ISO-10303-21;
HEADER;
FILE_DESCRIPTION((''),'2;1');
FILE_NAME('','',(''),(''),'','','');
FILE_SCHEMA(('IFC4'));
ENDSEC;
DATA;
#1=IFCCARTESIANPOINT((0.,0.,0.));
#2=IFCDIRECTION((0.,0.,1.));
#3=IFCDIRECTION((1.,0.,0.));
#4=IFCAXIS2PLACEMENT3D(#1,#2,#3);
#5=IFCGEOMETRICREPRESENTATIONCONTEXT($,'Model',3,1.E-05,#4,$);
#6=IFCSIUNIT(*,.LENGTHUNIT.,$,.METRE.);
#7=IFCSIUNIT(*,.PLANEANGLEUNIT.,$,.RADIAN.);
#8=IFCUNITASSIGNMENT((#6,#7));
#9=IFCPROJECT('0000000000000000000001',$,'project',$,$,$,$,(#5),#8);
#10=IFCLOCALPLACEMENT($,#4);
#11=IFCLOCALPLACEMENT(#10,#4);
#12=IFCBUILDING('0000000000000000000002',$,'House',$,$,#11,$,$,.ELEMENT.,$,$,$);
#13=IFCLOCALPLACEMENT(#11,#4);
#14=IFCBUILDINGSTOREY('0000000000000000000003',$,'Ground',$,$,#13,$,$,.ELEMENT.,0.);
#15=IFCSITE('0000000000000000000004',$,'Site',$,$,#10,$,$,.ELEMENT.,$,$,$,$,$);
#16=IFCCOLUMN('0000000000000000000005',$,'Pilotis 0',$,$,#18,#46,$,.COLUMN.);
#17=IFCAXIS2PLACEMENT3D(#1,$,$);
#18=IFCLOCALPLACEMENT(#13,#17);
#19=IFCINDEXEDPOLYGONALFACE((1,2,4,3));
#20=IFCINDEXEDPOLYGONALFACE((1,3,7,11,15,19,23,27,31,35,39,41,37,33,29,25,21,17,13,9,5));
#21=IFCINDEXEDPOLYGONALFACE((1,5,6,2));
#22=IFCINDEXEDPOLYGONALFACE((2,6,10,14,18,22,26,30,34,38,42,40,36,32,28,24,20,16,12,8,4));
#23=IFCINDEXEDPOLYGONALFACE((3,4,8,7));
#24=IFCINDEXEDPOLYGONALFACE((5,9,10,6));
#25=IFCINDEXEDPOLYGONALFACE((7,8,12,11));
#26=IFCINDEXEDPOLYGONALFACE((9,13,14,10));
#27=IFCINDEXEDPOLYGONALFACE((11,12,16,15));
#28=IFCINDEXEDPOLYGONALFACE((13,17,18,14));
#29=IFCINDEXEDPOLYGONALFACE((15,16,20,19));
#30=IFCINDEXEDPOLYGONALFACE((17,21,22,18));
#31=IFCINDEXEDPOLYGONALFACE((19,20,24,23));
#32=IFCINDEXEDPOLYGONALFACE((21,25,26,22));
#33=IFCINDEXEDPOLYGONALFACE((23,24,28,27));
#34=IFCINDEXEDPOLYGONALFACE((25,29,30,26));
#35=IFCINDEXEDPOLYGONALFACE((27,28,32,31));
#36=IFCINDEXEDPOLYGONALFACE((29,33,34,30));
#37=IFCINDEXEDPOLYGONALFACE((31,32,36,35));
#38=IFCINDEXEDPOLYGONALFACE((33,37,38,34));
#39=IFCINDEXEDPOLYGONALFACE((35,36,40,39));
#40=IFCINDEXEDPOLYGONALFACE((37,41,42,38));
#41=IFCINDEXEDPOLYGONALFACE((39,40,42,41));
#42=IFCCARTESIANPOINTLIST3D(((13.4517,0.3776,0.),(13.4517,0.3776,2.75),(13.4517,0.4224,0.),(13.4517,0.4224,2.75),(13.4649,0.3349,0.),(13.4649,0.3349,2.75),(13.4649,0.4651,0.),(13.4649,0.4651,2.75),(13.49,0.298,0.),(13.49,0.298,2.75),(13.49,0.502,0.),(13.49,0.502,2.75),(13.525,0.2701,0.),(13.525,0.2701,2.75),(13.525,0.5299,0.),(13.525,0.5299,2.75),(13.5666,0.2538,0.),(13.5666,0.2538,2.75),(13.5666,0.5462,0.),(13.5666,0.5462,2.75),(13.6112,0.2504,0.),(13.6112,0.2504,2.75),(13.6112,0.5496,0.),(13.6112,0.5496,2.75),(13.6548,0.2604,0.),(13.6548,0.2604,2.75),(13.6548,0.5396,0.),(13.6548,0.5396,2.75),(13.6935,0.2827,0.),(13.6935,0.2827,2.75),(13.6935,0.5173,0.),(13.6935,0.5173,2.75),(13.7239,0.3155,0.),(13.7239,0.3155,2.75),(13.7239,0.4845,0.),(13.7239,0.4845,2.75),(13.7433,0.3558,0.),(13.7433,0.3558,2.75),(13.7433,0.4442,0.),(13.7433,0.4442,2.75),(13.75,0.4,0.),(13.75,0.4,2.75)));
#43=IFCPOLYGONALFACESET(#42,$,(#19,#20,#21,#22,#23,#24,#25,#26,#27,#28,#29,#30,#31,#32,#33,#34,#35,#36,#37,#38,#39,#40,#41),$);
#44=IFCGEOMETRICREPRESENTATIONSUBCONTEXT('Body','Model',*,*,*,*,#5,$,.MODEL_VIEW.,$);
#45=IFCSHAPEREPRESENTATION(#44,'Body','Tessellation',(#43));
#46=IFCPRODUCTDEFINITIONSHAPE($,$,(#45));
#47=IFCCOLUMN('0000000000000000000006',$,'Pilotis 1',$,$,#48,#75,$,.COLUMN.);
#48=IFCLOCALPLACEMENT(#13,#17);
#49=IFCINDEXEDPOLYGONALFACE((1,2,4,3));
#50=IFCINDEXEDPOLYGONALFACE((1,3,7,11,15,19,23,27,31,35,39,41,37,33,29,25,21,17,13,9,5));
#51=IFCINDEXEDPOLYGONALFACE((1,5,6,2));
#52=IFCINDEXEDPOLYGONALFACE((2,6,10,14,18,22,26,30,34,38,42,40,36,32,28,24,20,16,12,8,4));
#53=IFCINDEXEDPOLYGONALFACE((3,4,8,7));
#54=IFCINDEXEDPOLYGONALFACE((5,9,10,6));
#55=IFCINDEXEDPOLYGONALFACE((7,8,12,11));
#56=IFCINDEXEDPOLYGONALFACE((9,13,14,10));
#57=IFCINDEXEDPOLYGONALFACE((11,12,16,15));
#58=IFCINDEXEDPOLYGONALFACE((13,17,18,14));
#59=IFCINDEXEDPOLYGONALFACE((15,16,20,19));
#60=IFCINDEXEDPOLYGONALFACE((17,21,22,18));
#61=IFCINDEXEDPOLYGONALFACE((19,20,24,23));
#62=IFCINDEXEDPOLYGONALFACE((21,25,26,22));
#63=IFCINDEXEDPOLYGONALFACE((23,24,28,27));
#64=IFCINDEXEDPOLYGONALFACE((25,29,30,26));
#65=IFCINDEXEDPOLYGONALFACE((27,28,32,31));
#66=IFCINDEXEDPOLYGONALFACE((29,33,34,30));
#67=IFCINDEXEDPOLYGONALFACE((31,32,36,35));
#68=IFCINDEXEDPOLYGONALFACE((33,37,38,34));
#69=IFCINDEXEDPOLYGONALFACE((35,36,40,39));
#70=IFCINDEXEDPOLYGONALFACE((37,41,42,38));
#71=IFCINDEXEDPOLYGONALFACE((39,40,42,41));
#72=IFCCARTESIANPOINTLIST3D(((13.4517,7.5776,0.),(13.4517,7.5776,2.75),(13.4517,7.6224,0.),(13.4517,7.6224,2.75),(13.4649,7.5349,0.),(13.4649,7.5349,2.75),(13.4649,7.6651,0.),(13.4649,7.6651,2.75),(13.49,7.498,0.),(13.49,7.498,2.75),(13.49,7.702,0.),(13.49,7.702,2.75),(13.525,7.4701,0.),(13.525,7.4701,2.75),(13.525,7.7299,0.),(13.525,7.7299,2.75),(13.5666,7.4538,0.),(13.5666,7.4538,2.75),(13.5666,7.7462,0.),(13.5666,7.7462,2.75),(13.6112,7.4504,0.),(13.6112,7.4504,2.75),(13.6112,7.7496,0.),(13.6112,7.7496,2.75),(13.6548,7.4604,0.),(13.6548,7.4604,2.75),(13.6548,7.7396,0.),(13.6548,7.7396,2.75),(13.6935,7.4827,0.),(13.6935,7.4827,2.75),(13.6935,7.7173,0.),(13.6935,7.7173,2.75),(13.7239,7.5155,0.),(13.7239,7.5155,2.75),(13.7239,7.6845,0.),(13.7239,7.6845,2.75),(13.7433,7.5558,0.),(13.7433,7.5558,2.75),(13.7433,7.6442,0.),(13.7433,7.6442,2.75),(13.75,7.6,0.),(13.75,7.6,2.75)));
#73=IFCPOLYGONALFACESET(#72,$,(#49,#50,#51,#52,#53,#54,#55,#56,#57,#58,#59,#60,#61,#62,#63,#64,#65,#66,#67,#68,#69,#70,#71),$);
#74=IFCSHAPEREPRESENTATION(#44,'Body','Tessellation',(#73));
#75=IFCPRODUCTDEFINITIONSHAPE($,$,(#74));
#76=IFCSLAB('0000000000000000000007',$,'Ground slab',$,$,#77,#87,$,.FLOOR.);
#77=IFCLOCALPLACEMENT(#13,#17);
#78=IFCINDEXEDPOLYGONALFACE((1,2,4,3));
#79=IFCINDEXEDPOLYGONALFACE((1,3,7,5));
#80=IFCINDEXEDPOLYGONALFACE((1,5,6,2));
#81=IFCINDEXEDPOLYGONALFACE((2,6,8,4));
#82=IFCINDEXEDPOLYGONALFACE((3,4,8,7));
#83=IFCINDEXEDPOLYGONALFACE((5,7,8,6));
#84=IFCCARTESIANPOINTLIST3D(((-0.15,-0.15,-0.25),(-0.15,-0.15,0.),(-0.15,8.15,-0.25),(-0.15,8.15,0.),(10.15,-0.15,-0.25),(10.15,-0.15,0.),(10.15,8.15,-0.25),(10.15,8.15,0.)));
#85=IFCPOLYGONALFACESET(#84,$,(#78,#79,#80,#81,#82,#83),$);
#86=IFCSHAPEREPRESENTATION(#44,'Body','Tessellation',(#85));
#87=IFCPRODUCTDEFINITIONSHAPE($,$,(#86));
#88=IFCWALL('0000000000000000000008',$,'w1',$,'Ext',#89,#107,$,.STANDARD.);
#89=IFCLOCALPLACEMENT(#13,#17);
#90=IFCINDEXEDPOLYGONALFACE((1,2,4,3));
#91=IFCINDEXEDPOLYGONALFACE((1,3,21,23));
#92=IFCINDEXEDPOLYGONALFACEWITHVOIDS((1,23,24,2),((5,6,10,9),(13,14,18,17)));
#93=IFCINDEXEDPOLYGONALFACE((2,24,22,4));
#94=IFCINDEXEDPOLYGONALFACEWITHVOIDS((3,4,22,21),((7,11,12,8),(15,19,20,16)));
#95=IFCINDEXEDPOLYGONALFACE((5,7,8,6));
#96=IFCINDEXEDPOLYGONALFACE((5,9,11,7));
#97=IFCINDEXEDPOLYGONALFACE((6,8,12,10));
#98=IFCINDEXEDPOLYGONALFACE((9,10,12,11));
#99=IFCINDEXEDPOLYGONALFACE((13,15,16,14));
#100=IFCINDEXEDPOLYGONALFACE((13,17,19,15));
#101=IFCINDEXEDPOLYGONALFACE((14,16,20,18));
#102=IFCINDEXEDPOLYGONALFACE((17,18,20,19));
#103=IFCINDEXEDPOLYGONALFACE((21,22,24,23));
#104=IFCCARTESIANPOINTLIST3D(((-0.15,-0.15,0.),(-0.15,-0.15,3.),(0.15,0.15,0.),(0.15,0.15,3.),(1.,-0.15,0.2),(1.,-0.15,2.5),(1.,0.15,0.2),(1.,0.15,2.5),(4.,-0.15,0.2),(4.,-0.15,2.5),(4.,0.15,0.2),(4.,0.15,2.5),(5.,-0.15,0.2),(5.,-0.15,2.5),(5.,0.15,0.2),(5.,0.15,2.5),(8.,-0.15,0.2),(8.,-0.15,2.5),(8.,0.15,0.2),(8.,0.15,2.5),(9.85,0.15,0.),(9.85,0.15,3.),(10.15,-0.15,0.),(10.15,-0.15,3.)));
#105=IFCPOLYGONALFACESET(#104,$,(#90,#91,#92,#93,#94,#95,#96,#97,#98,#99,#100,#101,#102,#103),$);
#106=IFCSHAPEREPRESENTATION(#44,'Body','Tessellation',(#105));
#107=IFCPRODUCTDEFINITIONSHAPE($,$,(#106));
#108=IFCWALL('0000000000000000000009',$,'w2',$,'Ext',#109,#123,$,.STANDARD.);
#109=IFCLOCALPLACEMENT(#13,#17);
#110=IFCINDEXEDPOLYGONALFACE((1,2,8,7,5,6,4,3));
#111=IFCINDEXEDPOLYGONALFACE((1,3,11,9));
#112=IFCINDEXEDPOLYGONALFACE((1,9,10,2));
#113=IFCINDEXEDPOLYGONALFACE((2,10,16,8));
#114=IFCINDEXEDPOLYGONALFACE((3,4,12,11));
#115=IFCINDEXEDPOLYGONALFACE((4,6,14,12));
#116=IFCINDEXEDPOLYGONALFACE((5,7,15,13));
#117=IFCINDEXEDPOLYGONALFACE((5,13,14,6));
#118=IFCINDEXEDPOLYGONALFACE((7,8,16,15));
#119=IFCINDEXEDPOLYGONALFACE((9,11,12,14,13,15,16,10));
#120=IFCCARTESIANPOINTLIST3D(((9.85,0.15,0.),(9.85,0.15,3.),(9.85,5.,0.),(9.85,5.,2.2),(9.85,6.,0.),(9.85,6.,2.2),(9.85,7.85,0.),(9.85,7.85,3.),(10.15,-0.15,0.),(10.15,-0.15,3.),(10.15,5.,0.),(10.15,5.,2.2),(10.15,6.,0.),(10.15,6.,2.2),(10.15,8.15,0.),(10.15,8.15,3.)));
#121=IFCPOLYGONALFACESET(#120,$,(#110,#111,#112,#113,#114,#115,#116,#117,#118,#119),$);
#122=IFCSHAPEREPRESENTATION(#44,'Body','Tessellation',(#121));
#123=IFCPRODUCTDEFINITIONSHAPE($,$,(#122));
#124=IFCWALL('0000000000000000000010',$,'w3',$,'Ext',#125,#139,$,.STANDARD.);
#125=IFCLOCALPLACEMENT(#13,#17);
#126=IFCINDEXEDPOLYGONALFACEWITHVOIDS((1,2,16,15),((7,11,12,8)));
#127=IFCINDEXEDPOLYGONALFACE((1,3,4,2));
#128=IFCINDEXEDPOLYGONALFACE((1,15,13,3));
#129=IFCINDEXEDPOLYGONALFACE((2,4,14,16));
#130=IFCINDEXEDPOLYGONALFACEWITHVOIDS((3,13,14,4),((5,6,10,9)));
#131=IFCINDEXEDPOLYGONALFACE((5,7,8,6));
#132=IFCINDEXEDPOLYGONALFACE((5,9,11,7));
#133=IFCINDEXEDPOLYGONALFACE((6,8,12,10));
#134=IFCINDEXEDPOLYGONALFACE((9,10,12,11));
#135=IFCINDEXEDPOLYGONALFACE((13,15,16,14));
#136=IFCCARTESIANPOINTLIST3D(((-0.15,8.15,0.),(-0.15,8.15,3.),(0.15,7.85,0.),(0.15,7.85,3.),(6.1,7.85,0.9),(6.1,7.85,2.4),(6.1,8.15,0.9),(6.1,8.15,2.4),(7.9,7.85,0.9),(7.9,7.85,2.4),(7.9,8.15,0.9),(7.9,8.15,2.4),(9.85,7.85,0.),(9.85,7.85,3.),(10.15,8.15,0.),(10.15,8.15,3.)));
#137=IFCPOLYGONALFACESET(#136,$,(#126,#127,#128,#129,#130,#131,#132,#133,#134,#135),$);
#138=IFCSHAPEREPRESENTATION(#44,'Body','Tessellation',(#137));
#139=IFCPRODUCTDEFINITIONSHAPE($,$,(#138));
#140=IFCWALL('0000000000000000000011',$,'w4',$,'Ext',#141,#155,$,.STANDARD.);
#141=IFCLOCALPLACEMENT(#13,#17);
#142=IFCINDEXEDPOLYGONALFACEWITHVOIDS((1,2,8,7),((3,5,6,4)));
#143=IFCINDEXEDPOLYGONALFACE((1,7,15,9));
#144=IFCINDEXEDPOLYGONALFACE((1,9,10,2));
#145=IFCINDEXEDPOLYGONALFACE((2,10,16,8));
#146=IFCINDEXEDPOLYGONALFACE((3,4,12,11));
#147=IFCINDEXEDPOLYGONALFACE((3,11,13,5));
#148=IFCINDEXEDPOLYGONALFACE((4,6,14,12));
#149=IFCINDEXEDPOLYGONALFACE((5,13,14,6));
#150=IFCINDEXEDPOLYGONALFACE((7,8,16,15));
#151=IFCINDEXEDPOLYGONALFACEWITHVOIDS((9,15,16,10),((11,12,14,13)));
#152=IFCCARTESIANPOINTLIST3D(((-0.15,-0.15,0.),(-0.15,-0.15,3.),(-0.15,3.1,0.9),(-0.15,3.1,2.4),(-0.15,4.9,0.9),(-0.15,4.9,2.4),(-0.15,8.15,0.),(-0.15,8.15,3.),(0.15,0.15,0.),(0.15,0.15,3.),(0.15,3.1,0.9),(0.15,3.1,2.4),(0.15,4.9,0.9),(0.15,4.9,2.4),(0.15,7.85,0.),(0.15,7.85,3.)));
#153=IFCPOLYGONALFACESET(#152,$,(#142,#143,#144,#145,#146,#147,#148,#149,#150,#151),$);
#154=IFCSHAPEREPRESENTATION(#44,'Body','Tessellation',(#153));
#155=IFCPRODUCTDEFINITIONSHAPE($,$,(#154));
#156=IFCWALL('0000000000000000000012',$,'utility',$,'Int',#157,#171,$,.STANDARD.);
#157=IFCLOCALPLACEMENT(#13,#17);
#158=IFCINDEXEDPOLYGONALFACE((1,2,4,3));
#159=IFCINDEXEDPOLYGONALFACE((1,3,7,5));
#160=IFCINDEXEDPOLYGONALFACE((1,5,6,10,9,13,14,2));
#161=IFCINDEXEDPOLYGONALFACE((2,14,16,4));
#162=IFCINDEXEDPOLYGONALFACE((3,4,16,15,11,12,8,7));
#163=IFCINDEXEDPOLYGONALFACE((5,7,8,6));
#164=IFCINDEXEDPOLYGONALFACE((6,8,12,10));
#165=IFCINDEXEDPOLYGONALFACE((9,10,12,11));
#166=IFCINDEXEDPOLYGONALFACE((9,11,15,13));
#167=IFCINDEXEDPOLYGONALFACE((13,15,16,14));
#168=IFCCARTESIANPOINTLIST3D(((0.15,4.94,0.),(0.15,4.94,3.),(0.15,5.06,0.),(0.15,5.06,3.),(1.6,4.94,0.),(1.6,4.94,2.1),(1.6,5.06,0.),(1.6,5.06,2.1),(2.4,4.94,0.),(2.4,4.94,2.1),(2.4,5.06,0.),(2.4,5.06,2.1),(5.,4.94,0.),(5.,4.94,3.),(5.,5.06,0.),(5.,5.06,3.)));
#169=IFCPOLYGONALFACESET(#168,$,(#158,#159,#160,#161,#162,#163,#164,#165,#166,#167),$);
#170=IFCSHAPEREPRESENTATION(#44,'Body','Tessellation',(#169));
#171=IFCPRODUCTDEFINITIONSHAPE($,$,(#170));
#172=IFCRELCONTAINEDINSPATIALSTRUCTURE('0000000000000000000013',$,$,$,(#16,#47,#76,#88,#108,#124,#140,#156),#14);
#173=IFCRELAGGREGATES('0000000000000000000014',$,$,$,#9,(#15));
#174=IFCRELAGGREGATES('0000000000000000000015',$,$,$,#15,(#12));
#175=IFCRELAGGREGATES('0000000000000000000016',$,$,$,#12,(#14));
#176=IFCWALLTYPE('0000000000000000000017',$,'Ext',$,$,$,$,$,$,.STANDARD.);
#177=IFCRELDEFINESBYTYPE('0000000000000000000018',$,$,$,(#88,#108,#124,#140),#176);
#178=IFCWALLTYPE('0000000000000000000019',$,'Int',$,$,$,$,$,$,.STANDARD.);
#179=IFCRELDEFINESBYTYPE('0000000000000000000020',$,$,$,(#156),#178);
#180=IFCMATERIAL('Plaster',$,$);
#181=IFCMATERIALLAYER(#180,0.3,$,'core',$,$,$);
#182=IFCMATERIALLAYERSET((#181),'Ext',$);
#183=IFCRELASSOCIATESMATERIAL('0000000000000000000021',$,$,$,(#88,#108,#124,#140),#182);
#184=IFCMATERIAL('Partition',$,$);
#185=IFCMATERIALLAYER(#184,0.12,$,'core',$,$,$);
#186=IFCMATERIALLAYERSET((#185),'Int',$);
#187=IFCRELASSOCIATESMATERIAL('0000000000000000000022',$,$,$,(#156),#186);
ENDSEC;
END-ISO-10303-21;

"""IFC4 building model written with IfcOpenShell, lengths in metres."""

from ifc_helpers import new_model, si_unit, frame, origin_with_axes, origin_2d_with_axis, place, context, subcontext, project, spatial, polyline, rectangle, circle, outline, extrude, material, layer, layer_set, layer_usage, type_object, element, save


model = new_model("IFC4")

# Units and contexts
model_context = context("Model", 3, precision=1e-05, world=origin_with_axes())
body_context = subcontext(model_context, "Body", "Model", "MODEL_VIEW")
ifc_project = project(units=[si_unit("LENGTHUNIT", "METRE"), si_unit("PLANEANGLEUNIT", "RADIAN")], contexts=[model_context])

# Site, building, storey
site_placement = place(None, origin_with_axes())
site = spatial("IfcSite", under=ifc_project, at=site_placement, Name="Site", CompositionType="ELEMENT")
building_placement = place(site_placement, origin_with_axes())
building = spatial("IfcBuilding", under=site, at=building_placement, Name="House", CompositionType="ELEMENT")
storey_placement = place(building_placement, origin_with_axes())
storey = spatial("IfcBuildingStorey", under=building, at=storey_placement, Name="Ground", CompositionType="ELEMENT", Elevation=0.0)

# Columns
for number, where, z_axis, x_axis, name in (
    (1, (13.6, 0.4, 0.0), (0.0, 0.0, 1.0), (1.0, 0.0, 0.0), "Pilotis 0"),
    (2, (13.6, 7.6, 0.0), (0.0, 0.0, 1.0), (1.0, 0.0, 0.0), "Pilotis 1"),
):
    element("IfcColumn", number, at=place(storey_placement, frame(where, z_axis=z_axis, x_axis=x_axis)), inside=storey, Name=name, PredefinedType="COLUMN", context=body_context, shape_type="SweptSolid", body=[
        extrude(circle(Radius=0.15, at=origin_2d_with_axis()), origin_with_axes(), (0.0, 0.0, 1.0), 2.75),
    ])

# Slab
slab_placement = place(storey_placement, frame((0.0, 0.0, -0.25), z_axis=(0.0, 0.0, 1.0), x_axis=(1.0, 0.0, 0.0)))
element("IfcSlab", 3, at=slab_placement, inside=storey, Name="Ground slab", PredefinedType="FLOOR", context=body_context, shape_type="SweptSolid", body=[
    extrude(outline(polyline([(10.15, -0.15), (10.15, 8.15), (-0.15, 8.15), (-0.15, -0.15), (10.15, -0.15)])), origin_with_axes(), (0.0, 0.0, 1.0), 0.25),
])

# Wall, openings
ifc_material_1 = material(Name="Plaster")
ifc_layer_1 = layer(ifc_material_1, 0.3, Name="core")
ifc_layer_set_1 = layer_set([ifc_layer_1], Name="Ext")
ifc_layer_usage_1 = layer_usage(ifc_layer_set_1, "AXIS2", "POSITIVE", -0.15)
wall_type_1 = type_object("IfcWallType", Name="Ext", PredefinedType="STANDARD")
wall_1_placement = place(storey_placement, origin_with_axes())
wall_1 = element("IfcWall", 4, at=wall_1_placement, inside=storey, type_object=wall_type_1, material=ifc_layer_usage_1, Name="w1", ObjectType="Ext", PredefinedType="STANDARD", context=body_context, shape_type="SweptSolid", body=[
    extrude(outline(polyline([(-0.15, -0.15), (10.15, -0.15), (10.0, 0.0), (9.85, 0.15), (0.15, 0.15), (0.0, 0.0), (-0.15, -0.15)])), origin_with_axes(), (0.0, 0.0, 1.0), 3.0),
])
opening_1_placement = place(wall_1_placement, frame((2.5, -0.16, 1.35), z_axis=(0.0, 1.0, 0.0), x_axis=(1.0, 0.0, 0.0)))
element("IfcOpeningElement", 5, at=opening_1_placement, cuts=wall_1, PredefinedType="OPENING", context=body_context, shape_type="SweptSolid", body=[
    extrude(rectangle(XDim=3.0, YDim=2.3, at=origin_2d_with_axis()), origin_with_axes(), (0.0, 0.0, 1.0), 0.32),
])
opening_2_placement = place(wall_1_placement, frame((6.5, -0.16, 1.35), z_axis=(0.0, 1.0, 0.0), x_axis=(1.0, 0.0, 0.0)))
element("IfcOpeningElement", 6, at=opening_2_placement, cuts=wall_1, PredefinedType="OPENING", context=body_context, shape_type="SweptSolid", body=[
    extrude(rectangle(XDim=3.0, YDim=2.3, at=origin_2d_with_axis()), origin_with_axes(), (0.0, 0.0, 1.0), 0.32),
])

# Walls, openings
ifc_layer_usage_2 = layer_usage(ifc_layer_set_1, "AXIS2", "POSITIVE", -0.15)
wall_2_placement = place(storey_placement, frame((10.0, 0.0, 0.0), z_axis=(0.0, 0.0, 1.0), x_axis=(0.0, 1.0, 0.0)))
wall_2 = element("IfcWall", 7, at=wall_2_placement, inside=storey, type_object=wall_type_1, material=ifc_layer_usage_2, Name="w2", ObjectType="Ext", PredefinedType="STANDARD", context=body_context, shape_type="SweptSolid", body=[
    extrude(outline(polyline([(-0.15, -0.15), (8.15, -0.15), (8.0, 0.0), (7.85, 0.15), (0.15, 0.15), (0.0, 0.0), (-0.15, -0.15)])), origin_with_axes(), (0.0, 0.0, 1.0), 3.0),
])
opening_3_placement = place(wall_2_placement, frame((5.5, -0.16, 1.1), z_axis=(0.0, 1.0, 0.0), x_axis=(1.0, 0.0, 0.0)))
element("IfcOpeningElement", 8, at=opening_3_placement, cuts=wall_2, PredefinedType="OPENING", context=body_context, shape_type="SweptSolid", body=[
    extrude(rectangle(XDim=1.0, YDim=2.2, at=origin_2d_with_axis()), origin_with_axes(), (0.0, 0.0, 1.0), 0.32),
])
ifc_layer_usage_3 = layer_usage(ifc_layer_set_1, "AXIS2", "POSITIVE", -0.15)
wall_3_placement = place(storey_placement, frame((10.0, 8.0, 0.0), z_axis=(0.0, 0.0, 1.0), x_axis=(-1.0, 0.0, 0.0)))
wall_3 = element("IfcWall", 9, at=wall_3_placement, inside=storey, type_object=wall_type_1, material=ifc_layer_usage_3, Name="w3", ObjectType="Ext", PredefinedType="STANDARD", context=body_context, shape_type="SweptSolid", body=[
    extrude(outline(polyline([(-0.15, -0.15), (10.15, -0.15), (10.0, 0.0), (9.85, 0.15), (0.15, 0.15), (0.0, 0.0), (-0.15, -0.15)])), origin_with_axes(), (0.0, 0.0, 1.0), 3.0),
])
opening_4_placement = place(wall_3_placement, frame((3.0, -0.16, 1.65), z_axis=(0.0, 1.0, 0.0), x_axis=(1.0, 0.0, 0.0)))
element("IfcOpeningElement", 10, at=opening_4_placement, cuts=wall_3, PredefinedType="OPENING", context=body_context, shape_type="SweptSolid", body=[
    extrude(rectangle(XDim=1.8, YDim=1.5, at=origin_2d_with_axis()), origin_with_axes(), (0.0, 0.0, 1.0), 0.32),
])
ifc_layer_usage_4 = layer_usage(ifc_layer_set_1, "AXIS2", "POSITIVE", -0.15)
wall_4_placement = place(storey_placement, frame((0.0, 8.0, 0.0), z_axis=(0.0, 0.0, 1.0), x_axis=(0.0, -1.0, 0.0)))
wall_4 = element("IfcWall", 11, at=wall_4_placement, inside=storey, type_object=wall_type_1, material=ifc_layer_usage_4, Name="w4", ObjectType="Ext", PredefinedType="STANDARD", context=body_context, shape_type="SweptSolid", body=[
    extrude(outline(polyline([(-0.15, -0.15), (8.15, -0.15), (8.0, 0.0), (7.85, 0.15), (0.15, 0.15), (0.0, 0.0), (-0.15, -0.15)])), origin_with_axes(), (0.0, 0.0, 1.0), 3.0),
])
opening_5_placement = place(wall_4_placement, frame((4.0, -0.16, 1.65), z_axis=(0.0, 1.0, 0.0), x_axis=(1.0, 0.0, 0.0)))
element("IfcOpeningElement", 12, at=opening_5_placement, cuts=wall_4, PredefinedType="OPENING", context=body_context, shape_type="SweptSolid", body=[
    extrude(rectangle(XDim=1.8, YDim=1.5, at=origin_2d_with_axis()), origin_with_axes(), (0.0, 0.0, 1.0), 0.32),
])
ifc_material_2 = material(Name="Partition")
ifc_layer_2 = layer(ifc_material_2, 0.12, Name="core")
ifc_layer_set_2 = layer_set([ifc_layer_2], Name="Int")
ifc_layer_usage_5 = layer_usage(ifc_layer_set_2, "AXIS2", "POSITIVE", -0.06)
wall_type_2 = type_object("IfcWallType", Name="Int", PredefinedType="STANDARD")
wall_5_placement = place(storey_placement, frame((0.0, 5.0, 0.0), z_axis=(0.0, 0.0, 1.0), x_axis=(1.0, 0.0, 0.0)))
wall_5 = element("IfcWall", 13, at=wall_5_placement, inside=storey, type_object=wall_type_2, material=ifc_layer_usage_5, Name="utility", ObjectType="Int", PredefinedType="STANDARD", context=body_context, shape_type="SweptSolid", body=[
    extrude(outline(polyline([(0.15, -0.06), (5.0, -0.06), (5.0, 0.06), (0.15, 0.06), (0.15, -0.06)])), origin_with_axes(), (0.0, 0.0, 1.0), 3.0),
])
opening_6_placement = place(wall_5_placement, frame((2.0, -0.07, 1.05), z_axis=(0.0, 1.0, 0.0), x_axis=(1.0, 0.0, 0.0)))
element("IfcOpeningElement", 14, at=opening_6_placement, cuts=wall_5, PredefinedType="OPENING", context=body_context, shape_type="SweptSolid", body=[
    extrude(rectangle(XDim=0.8, YDim=2.1, at=origin_2d_with_axis()), origin_with_axes(), (0.0, 0.0, 1.0), 0.14),
])

save(model, "model.ifc")
